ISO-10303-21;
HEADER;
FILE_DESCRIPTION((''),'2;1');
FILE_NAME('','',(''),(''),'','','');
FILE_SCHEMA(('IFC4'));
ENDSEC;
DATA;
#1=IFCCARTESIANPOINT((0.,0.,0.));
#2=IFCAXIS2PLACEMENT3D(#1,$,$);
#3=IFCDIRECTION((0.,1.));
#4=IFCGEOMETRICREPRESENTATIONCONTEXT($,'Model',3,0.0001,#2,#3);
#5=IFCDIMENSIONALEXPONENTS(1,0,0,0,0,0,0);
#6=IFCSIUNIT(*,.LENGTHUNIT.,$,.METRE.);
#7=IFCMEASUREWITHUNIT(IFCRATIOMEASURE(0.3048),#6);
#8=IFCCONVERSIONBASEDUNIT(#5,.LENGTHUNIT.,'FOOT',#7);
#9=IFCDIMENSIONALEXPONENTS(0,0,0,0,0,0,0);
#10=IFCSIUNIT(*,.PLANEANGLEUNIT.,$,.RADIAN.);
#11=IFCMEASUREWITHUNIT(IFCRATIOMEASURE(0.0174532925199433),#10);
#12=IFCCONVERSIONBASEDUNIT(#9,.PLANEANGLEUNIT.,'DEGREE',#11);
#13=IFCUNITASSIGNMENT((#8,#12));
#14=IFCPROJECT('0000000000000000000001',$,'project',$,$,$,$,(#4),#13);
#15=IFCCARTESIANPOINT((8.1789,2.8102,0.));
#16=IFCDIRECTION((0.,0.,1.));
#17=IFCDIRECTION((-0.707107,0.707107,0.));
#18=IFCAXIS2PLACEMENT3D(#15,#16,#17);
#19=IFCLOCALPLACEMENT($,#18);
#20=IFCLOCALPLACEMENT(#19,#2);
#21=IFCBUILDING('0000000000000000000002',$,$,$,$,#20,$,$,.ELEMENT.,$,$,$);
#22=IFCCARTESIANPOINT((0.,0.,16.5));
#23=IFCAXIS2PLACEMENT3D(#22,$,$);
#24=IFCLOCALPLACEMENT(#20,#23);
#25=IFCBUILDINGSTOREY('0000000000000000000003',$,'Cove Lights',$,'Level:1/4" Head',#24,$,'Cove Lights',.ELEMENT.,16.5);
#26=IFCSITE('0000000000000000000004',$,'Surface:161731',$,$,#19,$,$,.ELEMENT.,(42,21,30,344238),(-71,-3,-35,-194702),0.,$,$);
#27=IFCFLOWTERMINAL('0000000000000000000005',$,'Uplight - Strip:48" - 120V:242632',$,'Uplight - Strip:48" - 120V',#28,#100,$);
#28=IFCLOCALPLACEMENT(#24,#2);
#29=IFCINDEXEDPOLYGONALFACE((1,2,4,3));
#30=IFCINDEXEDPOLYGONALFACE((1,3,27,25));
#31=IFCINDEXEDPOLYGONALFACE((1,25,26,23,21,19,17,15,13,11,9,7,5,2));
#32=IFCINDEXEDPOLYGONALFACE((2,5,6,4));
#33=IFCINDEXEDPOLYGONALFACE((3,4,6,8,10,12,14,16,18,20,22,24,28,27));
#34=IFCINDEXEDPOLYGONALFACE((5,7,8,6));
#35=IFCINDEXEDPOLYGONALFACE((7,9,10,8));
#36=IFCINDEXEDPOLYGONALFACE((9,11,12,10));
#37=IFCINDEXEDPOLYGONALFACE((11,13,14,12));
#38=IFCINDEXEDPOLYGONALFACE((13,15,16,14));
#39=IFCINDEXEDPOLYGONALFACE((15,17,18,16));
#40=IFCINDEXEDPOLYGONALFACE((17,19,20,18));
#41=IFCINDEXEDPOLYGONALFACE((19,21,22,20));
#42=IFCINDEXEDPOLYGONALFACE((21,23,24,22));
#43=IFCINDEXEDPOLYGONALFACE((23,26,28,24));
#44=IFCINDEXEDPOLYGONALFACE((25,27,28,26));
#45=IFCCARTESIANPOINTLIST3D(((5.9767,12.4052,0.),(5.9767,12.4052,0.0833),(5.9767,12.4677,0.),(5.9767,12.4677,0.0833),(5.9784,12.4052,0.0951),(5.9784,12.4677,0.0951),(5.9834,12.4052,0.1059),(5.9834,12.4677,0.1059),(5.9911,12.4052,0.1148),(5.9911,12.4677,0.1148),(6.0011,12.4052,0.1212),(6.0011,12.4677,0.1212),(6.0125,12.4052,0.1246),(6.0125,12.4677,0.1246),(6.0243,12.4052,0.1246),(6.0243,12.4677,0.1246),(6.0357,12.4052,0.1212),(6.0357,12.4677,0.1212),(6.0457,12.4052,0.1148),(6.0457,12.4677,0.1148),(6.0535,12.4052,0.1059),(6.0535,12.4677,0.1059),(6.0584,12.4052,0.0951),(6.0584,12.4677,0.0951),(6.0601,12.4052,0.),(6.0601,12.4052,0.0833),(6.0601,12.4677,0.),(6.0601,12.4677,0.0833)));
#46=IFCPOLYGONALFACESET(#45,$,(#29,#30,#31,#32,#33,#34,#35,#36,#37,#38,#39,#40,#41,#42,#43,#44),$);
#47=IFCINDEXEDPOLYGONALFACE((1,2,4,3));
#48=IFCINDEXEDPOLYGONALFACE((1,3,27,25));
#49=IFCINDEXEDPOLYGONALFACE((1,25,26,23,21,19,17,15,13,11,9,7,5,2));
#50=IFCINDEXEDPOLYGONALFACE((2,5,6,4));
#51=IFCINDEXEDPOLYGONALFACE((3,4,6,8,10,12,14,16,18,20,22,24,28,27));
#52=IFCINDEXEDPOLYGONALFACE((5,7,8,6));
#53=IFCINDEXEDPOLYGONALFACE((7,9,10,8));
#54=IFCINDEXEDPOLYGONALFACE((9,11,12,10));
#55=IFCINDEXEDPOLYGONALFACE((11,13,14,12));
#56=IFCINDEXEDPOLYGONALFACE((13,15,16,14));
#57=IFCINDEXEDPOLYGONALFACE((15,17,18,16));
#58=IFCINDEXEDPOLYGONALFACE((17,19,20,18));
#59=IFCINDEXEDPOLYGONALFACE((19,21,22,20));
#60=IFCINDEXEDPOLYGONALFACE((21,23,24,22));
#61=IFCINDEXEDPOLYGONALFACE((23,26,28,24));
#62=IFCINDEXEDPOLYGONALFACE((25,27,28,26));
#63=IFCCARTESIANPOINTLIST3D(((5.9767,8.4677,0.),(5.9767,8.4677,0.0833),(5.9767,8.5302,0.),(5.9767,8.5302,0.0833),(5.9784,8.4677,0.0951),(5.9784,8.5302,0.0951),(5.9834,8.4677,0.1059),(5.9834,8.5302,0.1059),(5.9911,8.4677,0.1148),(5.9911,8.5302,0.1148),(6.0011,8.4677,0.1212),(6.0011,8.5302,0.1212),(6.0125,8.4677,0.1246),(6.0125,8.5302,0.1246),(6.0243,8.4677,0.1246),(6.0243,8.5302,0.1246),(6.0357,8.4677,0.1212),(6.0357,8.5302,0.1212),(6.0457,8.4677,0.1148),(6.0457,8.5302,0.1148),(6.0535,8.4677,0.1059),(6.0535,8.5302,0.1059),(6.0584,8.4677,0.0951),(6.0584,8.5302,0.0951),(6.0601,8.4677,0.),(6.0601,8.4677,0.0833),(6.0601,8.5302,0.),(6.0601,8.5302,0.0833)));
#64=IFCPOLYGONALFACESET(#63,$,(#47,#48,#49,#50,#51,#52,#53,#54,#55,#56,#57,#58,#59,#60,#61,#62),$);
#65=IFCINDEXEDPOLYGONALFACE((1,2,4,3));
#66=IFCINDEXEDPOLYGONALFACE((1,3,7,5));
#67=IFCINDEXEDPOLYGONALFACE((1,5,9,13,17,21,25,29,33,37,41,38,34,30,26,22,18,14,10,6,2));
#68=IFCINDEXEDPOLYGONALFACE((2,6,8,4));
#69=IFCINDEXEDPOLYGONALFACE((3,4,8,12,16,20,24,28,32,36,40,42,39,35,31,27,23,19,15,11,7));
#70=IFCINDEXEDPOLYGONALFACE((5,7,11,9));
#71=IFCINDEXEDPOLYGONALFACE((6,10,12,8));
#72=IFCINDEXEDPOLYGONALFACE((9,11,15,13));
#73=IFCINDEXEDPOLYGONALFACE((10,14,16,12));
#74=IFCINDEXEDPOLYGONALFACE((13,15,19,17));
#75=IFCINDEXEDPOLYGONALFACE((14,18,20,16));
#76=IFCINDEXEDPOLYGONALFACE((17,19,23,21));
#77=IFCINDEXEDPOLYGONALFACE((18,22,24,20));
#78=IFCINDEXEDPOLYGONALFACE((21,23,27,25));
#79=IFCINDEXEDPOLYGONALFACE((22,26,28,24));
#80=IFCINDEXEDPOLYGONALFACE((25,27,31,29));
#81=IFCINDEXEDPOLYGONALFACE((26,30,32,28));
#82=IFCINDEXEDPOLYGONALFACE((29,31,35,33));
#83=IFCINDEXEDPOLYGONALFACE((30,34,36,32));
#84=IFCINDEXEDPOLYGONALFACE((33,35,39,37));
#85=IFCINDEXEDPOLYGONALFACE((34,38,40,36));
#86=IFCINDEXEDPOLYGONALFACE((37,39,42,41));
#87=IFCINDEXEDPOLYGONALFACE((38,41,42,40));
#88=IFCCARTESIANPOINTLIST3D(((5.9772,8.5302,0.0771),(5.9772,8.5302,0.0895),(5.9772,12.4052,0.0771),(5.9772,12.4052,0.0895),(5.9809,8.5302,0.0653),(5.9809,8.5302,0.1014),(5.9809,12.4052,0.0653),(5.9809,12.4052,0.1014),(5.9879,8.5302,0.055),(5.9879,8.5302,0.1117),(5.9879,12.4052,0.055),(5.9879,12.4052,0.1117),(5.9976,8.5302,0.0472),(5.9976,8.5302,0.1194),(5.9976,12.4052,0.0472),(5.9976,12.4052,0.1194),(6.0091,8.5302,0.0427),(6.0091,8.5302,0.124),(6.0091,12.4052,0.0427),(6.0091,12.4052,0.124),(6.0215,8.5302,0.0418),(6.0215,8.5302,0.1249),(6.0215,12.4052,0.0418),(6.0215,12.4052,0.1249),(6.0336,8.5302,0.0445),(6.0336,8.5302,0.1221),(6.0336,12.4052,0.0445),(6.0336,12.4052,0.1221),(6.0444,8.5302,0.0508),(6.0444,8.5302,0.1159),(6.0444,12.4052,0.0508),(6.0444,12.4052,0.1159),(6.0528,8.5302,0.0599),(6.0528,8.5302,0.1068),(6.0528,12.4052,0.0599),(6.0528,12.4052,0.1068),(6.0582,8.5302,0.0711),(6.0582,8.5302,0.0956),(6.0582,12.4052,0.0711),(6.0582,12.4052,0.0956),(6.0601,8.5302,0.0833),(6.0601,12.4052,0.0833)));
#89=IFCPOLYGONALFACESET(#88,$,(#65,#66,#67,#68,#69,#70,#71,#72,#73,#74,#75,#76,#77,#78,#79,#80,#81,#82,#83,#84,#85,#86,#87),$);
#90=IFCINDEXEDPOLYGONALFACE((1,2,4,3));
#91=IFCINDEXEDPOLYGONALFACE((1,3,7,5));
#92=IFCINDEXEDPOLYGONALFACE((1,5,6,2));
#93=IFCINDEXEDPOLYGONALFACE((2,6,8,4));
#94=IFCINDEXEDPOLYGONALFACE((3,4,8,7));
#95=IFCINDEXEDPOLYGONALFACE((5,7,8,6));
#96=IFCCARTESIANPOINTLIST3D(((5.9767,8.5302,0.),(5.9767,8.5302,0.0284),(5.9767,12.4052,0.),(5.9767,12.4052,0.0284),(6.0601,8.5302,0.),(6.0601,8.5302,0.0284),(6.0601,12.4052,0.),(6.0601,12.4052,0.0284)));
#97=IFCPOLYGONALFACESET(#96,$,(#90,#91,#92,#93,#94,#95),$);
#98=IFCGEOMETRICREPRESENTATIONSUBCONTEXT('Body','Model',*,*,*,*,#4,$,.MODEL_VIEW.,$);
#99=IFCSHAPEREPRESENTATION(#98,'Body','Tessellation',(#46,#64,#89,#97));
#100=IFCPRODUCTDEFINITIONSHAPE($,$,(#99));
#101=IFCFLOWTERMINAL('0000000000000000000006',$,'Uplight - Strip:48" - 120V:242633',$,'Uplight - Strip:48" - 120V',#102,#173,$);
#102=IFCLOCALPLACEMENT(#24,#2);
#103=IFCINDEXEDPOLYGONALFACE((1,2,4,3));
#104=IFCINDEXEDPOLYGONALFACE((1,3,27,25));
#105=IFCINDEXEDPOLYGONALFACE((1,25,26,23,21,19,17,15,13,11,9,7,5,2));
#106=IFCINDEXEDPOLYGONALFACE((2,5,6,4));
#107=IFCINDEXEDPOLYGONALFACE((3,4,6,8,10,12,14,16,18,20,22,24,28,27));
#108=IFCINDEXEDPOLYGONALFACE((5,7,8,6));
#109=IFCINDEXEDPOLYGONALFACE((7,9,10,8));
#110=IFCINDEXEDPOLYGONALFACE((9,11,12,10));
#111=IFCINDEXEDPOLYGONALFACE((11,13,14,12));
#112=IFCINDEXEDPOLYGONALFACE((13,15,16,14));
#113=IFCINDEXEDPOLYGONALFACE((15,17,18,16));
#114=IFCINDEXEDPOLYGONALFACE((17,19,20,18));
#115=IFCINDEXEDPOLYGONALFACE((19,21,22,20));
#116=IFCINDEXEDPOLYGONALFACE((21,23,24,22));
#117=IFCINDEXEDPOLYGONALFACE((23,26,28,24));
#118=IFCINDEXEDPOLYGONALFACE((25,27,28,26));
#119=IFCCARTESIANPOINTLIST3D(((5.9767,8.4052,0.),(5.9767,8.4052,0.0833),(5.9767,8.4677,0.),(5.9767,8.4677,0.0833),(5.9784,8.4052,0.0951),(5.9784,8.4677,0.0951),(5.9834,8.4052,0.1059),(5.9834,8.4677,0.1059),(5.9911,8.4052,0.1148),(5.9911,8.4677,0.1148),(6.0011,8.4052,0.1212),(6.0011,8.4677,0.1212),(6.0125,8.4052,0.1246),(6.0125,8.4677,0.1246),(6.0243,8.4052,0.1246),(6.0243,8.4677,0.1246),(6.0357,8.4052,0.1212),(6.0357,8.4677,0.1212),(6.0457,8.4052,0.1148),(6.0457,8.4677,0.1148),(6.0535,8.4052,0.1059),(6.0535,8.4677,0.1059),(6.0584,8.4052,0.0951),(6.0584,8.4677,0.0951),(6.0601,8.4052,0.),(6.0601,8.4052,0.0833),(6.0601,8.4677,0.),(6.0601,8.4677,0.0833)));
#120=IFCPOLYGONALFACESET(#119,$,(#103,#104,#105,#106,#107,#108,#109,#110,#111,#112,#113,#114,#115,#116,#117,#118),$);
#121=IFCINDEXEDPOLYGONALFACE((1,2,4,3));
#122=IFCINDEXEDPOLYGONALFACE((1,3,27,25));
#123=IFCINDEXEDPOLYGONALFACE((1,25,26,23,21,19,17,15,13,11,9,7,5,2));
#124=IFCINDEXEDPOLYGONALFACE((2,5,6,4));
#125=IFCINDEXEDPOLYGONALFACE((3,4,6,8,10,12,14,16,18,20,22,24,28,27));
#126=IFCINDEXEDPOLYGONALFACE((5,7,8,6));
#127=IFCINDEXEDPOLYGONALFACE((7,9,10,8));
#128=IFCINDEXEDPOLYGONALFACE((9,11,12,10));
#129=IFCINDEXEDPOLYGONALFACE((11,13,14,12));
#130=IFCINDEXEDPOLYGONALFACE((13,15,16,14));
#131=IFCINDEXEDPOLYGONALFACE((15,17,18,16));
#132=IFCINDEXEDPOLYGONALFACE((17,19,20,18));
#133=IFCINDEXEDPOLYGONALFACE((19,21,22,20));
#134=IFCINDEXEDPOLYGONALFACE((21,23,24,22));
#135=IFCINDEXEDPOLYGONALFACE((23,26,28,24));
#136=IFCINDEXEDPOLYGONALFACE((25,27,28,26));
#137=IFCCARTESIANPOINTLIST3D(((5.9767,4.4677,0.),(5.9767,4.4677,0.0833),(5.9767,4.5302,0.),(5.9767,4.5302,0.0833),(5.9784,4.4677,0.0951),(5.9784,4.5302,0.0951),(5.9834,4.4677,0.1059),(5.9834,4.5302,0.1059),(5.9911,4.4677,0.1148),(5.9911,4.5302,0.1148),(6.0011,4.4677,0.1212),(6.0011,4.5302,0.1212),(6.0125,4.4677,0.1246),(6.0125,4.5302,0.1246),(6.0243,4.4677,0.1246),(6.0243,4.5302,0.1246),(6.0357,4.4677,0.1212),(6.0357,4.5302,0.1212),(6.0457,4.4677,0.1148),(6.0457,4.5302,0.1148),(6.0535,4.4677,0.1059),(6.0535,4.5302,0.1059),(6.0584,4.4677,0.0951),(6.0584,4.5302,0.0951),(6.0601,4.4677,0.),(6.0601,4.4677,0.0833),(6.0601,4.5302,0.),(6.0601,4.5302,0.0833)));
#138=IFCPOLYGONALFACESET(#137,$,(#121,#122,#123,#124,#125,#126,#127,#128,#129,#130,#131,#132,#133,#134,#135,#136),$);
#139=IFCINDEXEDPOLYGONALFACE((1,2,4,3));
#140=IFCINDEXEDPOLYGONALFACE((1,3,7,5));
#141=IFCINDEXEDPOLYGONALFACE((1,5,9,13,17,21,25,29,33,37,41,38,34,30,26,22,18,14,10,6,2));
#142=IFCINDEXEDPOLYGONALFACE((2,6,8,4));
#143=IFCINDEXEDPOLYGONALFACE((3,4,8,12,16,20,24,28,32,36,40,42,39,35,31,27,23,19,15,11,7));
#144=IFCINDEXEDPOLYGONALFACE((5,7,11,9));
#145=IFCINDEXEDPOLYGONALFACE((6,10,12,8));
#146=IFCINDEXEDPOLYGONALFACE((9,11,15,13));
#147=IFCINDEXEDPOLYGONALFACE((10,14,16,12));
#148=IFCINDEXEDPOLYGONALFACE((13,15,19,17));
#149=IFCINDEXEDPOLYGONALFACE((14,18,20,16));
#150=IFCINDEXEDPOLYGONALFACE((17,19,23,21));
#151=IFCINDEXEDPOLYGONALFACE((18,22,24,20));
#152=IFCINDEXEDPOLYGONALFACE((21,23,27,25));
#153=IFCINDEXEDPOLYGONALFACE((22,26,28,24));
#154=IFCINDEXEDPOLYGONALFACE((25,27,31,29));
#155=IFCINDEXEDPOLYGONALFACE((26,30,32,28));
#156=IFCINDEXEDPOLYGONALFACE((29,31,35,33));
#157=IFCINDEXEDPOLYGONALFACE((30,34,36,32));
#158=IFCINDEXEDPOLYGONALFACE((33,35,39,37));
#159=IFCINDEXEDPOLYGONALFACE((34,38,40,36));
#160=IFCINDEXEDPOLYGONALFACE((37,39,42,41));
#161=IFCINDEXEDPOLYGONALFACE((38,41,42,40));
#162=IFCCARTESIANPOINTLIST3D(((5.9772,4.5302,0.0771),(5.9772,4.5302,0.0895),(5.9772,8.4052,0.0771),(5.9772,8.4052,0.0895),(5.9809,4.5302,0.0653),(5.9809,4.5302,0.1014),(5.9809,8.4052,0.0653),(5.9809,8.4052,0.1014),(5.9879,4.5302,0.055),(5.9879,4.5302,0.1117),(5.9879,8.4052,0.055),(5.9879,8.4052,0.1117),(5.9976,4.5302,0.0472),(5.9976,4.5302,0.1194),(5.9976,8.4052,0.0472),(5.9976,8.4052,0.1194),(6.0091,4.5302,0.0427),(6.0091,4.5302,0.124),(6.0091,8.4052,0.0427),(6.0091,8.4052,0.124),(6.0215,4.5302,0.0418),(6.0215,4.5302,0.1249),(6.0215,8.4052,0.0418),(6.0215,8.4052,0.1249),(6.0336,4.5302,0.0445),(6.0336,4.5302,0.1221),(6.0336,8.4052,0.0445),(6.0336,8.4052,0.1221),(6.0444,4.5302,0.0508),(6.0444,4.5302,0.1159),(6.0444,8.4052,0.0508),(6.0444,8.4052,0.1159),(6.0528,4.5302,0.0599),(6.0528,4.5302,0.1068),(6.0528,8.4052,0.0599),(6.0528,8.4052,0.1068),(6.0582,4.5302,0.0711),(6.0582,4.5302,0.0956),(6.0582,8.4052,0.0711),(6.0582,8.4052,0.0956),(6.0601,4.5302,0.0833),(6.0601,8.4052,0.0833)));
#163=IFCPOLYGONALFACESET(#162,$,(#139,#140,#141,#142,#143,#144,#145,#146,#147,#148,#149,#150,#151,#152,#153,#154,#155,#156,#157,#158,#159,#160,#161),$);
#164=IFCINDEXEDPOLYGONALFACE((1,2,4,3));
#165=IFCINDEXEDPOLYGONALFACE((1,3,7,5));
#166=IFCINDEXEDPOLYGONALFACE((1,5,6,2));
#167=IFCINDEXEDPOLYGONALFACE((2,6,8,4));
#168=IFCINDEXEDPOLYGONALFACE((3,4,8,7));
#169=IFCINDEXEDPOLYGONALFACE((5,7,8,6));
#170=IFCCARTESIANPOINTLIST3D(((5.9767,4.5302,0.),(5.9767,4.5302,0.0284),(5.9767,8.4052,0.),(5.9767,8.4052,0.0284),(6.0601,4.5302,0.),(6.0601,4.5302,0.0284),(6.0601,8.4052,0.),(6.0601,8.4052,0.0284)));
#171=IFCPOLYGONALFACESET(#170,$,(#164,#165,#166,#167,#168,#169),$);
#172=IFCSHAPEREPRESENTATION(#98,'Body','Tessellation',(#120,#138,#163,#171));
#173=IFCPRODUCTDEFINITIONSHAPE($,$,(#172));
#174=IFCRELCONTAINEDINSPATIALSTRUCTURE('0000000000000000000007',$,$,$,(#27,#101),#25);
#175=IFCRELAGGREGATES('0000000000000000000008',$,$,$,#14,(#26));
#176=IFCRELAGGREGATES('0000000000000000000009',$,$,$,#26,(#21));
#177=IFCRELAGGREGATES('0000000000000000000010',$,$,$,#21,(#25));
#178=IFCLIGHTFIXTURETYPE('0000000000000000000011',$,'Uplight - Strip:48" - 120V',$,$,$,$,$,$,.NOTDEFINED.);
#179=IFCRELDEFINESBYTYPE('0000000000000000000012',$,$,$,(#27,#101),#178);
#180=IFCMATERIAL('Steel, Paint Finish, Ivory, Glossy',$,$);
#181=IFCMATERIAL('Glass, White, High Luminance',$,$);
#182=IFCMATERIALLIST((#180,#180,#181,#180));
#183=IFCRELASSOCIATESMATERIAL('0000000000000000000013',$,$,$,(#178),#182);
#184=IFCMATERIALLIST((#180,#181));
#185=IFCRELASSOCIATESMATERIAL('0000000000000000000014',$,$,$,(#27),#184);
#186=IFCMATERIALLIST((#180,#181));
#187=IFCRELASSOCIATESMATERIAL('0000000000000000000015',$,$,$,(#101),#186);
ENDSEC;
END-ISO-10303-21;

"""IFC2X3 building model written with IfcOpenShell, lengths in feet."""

from ifc_helpers import new_model, entity, si_unit, converted_unit, direction, frame, frame_2d, origin, origin_2d_with_axis, place, context, subcontext, project, spatial, polyline, circle_curve, parameter, trimmed, segment, composite_curve, rectangle, circle, outline, extrude, source, transform, mapped, material, material_list, type_object, type_shapes, element, save


model = new_model("IFC2X3")

# Units and contexts
model_context = context("Model", 3, precision=0.0001, world=origin(), true_north=direction((0.0, 1.0)))
body_context = subcontext(model_context, "Body", "Model", "MODEL_VIEW")
ifc_project = project(units=[converted_unit("LENGTHUNIT", "FOOT", entity("IfcRatioMeasure", 0.3048), si_unit("LENGTHUNIT", "METRE"), dimensions=[1, 0, 0, 0, 0, 0, 0]), converted_unit("PLANEANGLEUNIT", "DEGREE", entity("IfcRatioMeasure", 0.0174532925199433), si_unit("PLANEANGLEUNIT", "RADIAN"), dimensions=[0, 0, 0, 0, 0, 0, 0])], contexts=[model_context])

# Site, building, storey
site_placement = place(None, frame((8.1789, 2.8102, 0.0), z_axis=(0.0, 0.0, 1.0), x_axis=(-0.707107, 0.707107, 0.0)))
site = spatial("IfcSite", under=ifc_project, at=site_placement, Name="Surface:161731", CompositionType="ELEMENT", RefLatitude=(42, 21, 30, 344238), RefLongitude=(-71, -3, -35, -194702), RefElevation=0.0)
building_placement = place(site_placement, origin())
building = spatial("IfcBuilding", under=site, at=building_placement, CompositionType="ELEMENT")
storey_placement = place(building_placement, frame((0.0, 0.0, 16.5)))
storey = spatial("IfcBuildingStorey", under=building, at=storey_placement, Name="Cove Lights", ObjectType="Level:1/4\" Head", LongName="Cove Lights", CompositionType="ELEMENT", Elevation=16.5)

# Flow terminals
ifc_material_1 = material(Name="Steel, Paint Finish, Ivory, Glossy")
ifc_material_2 = material(Name="Glass, White, High Luminance")
ifc_material_list_1 = material_list([ifc_material_1, ifc_material_1, ifc_material_2, ifc_material_1])
light_fixture_type_1 = type_object("IfcLightFixtureType", Name="Uplight - Strip:48\" - 120V", PredefinedType="NOTDEFINED", material=ifc_material_list_1)
shared_shape_1 = source(origin(), body_context, "Body", "SweptSolid", [
    extrude(outline(composite_curve([segment(polyline([(-0.0417, -0.0417), (0.0417, -0.0417)]), True, "CONTINUOUS"), segment(polyline([(0.0417, -0.0417), (0.0417, 0.0417)]), True, "CONTINUOUS"), segment(trimmed(circle_curve(frame_2d((0.0, 0.0417), x_axis=(-1.0, 0.0)), 0.0417), [parameter(180.0)], [parameter(0.0)], True, "PARAMETER"), True, "CONTINUOUS"), segment(polyline([(-0.0417, 0.0417), (-0.0417, -0.0417)]), True, "CONTINUOUS")], self_intersect=False)), frame((1.9375, 0.0, 0.0417), z_axis=(1.0, 0.0, 0.0), x_axis=(0.0, 1.0, 0.0)), (0.0, 0.0, 1.0), 0.0625),
    extrude(outline(composite_curve([segment(polyline([(-0.0417, -0.0417), (0.0417, -0.0417)]), True, "CONTINUOUS"), segment(trimmed(circle_curve(frame_2d((0.0417, 0.0), x_axis=(1.0, 0.0)), 0.0417), [parameter(270.0)], [parameter(90.0)], True, "PARAMETER"), True, "CONTINUOUS"), segment(polyline([(0.0417, 0.0417), (-0.0417, 0.0417)]), True, "CONTINUOUS"), segment(polyline([(-0.0417, 0.0417), (-0.0417, -0.0417)]), True, "CONTINUOUS")], self_intersect=False)), frame((-2.0, 0.0, 0.0417), z_axis=(1.0, 0.0, 0.0), x_axis=(0.0, 0.0, 1.0)), (0.0, 0.0, 1.0), 0.0625),
    extrude(circle(Radius=0.0417, at=frame_2d((0.0, 0.0), x_axis=(1.0, 0.0))), frame((-1.9375, 0.0, 0.0833), z_axis=(1.0, 0.0, 0.0), x_axis=(0.0, -1.0, 0.0)), (0.0, 0.0, 1.0), 3.875),
    extrude(rectangle(XDim=0.0833, YDim=3.875, at=origin_2d_with_axis()), frame((0.0, 0.0, 0.0), z_axis=(0.0, 0.0, 1.0), x_axis=(0.0, 1.0, 0.0)), (0.0, 0.0, 1.0), 0.0284),
])
type_shapes(light_fixture_type_1, [shared_shape_1])
ifc_material_list_2 = material_list([ifc_material_1, ifc_material_2])
flow_terminal_1_placement = place(storey_placement, frame((6.0184, 10.4677, 0.0), z_axis=(0.0, 0.0, 1.0), x_axis=(0.0, 1.0, 0.0)))
element("IfcFlowTerminal", 1, at=flow_terminal_1_placement, inside=storey, type_object=light_fixture_type_1, material=ifc_material_list_2, Name="Uplight - Strip:48\" - 120V:242632", ObjectType="Uplight - Strip:48\" - 120V", context=body_context, shape_type="MappedRepresentation", body=[
    mapped(shared_shape_1, transform((0.0, 0.0, 0.0), scale=1.0)),
])
ifc_material_list_3 = material_list([ifc_material_1, ifc_material_2])
flow_terminal_2_placement = place(storey_placement, frame((6.0184, 6.4677, 0.0), z_axis=(0.0, 0.0, 1.0), x_axis=(0.0, 1.0, 0.0)))
element("IfcFlowTerminal", 2, at=flow_terminal_2_placement, inside=storey, type_object=light_fixture_type_1, material=ifc_material_list_3, Name="Uplight - Strip:48\" - 120V:242633", ObjectType="Uplight - Strip:48\" - 120V", context=body_context, shape_type="MappedRepresentation", body=[
    mapped(shared_shape_1, transform((0.0, 0.0, 0.0), scale=1.0)),
])

save(model, "model.ifc")
